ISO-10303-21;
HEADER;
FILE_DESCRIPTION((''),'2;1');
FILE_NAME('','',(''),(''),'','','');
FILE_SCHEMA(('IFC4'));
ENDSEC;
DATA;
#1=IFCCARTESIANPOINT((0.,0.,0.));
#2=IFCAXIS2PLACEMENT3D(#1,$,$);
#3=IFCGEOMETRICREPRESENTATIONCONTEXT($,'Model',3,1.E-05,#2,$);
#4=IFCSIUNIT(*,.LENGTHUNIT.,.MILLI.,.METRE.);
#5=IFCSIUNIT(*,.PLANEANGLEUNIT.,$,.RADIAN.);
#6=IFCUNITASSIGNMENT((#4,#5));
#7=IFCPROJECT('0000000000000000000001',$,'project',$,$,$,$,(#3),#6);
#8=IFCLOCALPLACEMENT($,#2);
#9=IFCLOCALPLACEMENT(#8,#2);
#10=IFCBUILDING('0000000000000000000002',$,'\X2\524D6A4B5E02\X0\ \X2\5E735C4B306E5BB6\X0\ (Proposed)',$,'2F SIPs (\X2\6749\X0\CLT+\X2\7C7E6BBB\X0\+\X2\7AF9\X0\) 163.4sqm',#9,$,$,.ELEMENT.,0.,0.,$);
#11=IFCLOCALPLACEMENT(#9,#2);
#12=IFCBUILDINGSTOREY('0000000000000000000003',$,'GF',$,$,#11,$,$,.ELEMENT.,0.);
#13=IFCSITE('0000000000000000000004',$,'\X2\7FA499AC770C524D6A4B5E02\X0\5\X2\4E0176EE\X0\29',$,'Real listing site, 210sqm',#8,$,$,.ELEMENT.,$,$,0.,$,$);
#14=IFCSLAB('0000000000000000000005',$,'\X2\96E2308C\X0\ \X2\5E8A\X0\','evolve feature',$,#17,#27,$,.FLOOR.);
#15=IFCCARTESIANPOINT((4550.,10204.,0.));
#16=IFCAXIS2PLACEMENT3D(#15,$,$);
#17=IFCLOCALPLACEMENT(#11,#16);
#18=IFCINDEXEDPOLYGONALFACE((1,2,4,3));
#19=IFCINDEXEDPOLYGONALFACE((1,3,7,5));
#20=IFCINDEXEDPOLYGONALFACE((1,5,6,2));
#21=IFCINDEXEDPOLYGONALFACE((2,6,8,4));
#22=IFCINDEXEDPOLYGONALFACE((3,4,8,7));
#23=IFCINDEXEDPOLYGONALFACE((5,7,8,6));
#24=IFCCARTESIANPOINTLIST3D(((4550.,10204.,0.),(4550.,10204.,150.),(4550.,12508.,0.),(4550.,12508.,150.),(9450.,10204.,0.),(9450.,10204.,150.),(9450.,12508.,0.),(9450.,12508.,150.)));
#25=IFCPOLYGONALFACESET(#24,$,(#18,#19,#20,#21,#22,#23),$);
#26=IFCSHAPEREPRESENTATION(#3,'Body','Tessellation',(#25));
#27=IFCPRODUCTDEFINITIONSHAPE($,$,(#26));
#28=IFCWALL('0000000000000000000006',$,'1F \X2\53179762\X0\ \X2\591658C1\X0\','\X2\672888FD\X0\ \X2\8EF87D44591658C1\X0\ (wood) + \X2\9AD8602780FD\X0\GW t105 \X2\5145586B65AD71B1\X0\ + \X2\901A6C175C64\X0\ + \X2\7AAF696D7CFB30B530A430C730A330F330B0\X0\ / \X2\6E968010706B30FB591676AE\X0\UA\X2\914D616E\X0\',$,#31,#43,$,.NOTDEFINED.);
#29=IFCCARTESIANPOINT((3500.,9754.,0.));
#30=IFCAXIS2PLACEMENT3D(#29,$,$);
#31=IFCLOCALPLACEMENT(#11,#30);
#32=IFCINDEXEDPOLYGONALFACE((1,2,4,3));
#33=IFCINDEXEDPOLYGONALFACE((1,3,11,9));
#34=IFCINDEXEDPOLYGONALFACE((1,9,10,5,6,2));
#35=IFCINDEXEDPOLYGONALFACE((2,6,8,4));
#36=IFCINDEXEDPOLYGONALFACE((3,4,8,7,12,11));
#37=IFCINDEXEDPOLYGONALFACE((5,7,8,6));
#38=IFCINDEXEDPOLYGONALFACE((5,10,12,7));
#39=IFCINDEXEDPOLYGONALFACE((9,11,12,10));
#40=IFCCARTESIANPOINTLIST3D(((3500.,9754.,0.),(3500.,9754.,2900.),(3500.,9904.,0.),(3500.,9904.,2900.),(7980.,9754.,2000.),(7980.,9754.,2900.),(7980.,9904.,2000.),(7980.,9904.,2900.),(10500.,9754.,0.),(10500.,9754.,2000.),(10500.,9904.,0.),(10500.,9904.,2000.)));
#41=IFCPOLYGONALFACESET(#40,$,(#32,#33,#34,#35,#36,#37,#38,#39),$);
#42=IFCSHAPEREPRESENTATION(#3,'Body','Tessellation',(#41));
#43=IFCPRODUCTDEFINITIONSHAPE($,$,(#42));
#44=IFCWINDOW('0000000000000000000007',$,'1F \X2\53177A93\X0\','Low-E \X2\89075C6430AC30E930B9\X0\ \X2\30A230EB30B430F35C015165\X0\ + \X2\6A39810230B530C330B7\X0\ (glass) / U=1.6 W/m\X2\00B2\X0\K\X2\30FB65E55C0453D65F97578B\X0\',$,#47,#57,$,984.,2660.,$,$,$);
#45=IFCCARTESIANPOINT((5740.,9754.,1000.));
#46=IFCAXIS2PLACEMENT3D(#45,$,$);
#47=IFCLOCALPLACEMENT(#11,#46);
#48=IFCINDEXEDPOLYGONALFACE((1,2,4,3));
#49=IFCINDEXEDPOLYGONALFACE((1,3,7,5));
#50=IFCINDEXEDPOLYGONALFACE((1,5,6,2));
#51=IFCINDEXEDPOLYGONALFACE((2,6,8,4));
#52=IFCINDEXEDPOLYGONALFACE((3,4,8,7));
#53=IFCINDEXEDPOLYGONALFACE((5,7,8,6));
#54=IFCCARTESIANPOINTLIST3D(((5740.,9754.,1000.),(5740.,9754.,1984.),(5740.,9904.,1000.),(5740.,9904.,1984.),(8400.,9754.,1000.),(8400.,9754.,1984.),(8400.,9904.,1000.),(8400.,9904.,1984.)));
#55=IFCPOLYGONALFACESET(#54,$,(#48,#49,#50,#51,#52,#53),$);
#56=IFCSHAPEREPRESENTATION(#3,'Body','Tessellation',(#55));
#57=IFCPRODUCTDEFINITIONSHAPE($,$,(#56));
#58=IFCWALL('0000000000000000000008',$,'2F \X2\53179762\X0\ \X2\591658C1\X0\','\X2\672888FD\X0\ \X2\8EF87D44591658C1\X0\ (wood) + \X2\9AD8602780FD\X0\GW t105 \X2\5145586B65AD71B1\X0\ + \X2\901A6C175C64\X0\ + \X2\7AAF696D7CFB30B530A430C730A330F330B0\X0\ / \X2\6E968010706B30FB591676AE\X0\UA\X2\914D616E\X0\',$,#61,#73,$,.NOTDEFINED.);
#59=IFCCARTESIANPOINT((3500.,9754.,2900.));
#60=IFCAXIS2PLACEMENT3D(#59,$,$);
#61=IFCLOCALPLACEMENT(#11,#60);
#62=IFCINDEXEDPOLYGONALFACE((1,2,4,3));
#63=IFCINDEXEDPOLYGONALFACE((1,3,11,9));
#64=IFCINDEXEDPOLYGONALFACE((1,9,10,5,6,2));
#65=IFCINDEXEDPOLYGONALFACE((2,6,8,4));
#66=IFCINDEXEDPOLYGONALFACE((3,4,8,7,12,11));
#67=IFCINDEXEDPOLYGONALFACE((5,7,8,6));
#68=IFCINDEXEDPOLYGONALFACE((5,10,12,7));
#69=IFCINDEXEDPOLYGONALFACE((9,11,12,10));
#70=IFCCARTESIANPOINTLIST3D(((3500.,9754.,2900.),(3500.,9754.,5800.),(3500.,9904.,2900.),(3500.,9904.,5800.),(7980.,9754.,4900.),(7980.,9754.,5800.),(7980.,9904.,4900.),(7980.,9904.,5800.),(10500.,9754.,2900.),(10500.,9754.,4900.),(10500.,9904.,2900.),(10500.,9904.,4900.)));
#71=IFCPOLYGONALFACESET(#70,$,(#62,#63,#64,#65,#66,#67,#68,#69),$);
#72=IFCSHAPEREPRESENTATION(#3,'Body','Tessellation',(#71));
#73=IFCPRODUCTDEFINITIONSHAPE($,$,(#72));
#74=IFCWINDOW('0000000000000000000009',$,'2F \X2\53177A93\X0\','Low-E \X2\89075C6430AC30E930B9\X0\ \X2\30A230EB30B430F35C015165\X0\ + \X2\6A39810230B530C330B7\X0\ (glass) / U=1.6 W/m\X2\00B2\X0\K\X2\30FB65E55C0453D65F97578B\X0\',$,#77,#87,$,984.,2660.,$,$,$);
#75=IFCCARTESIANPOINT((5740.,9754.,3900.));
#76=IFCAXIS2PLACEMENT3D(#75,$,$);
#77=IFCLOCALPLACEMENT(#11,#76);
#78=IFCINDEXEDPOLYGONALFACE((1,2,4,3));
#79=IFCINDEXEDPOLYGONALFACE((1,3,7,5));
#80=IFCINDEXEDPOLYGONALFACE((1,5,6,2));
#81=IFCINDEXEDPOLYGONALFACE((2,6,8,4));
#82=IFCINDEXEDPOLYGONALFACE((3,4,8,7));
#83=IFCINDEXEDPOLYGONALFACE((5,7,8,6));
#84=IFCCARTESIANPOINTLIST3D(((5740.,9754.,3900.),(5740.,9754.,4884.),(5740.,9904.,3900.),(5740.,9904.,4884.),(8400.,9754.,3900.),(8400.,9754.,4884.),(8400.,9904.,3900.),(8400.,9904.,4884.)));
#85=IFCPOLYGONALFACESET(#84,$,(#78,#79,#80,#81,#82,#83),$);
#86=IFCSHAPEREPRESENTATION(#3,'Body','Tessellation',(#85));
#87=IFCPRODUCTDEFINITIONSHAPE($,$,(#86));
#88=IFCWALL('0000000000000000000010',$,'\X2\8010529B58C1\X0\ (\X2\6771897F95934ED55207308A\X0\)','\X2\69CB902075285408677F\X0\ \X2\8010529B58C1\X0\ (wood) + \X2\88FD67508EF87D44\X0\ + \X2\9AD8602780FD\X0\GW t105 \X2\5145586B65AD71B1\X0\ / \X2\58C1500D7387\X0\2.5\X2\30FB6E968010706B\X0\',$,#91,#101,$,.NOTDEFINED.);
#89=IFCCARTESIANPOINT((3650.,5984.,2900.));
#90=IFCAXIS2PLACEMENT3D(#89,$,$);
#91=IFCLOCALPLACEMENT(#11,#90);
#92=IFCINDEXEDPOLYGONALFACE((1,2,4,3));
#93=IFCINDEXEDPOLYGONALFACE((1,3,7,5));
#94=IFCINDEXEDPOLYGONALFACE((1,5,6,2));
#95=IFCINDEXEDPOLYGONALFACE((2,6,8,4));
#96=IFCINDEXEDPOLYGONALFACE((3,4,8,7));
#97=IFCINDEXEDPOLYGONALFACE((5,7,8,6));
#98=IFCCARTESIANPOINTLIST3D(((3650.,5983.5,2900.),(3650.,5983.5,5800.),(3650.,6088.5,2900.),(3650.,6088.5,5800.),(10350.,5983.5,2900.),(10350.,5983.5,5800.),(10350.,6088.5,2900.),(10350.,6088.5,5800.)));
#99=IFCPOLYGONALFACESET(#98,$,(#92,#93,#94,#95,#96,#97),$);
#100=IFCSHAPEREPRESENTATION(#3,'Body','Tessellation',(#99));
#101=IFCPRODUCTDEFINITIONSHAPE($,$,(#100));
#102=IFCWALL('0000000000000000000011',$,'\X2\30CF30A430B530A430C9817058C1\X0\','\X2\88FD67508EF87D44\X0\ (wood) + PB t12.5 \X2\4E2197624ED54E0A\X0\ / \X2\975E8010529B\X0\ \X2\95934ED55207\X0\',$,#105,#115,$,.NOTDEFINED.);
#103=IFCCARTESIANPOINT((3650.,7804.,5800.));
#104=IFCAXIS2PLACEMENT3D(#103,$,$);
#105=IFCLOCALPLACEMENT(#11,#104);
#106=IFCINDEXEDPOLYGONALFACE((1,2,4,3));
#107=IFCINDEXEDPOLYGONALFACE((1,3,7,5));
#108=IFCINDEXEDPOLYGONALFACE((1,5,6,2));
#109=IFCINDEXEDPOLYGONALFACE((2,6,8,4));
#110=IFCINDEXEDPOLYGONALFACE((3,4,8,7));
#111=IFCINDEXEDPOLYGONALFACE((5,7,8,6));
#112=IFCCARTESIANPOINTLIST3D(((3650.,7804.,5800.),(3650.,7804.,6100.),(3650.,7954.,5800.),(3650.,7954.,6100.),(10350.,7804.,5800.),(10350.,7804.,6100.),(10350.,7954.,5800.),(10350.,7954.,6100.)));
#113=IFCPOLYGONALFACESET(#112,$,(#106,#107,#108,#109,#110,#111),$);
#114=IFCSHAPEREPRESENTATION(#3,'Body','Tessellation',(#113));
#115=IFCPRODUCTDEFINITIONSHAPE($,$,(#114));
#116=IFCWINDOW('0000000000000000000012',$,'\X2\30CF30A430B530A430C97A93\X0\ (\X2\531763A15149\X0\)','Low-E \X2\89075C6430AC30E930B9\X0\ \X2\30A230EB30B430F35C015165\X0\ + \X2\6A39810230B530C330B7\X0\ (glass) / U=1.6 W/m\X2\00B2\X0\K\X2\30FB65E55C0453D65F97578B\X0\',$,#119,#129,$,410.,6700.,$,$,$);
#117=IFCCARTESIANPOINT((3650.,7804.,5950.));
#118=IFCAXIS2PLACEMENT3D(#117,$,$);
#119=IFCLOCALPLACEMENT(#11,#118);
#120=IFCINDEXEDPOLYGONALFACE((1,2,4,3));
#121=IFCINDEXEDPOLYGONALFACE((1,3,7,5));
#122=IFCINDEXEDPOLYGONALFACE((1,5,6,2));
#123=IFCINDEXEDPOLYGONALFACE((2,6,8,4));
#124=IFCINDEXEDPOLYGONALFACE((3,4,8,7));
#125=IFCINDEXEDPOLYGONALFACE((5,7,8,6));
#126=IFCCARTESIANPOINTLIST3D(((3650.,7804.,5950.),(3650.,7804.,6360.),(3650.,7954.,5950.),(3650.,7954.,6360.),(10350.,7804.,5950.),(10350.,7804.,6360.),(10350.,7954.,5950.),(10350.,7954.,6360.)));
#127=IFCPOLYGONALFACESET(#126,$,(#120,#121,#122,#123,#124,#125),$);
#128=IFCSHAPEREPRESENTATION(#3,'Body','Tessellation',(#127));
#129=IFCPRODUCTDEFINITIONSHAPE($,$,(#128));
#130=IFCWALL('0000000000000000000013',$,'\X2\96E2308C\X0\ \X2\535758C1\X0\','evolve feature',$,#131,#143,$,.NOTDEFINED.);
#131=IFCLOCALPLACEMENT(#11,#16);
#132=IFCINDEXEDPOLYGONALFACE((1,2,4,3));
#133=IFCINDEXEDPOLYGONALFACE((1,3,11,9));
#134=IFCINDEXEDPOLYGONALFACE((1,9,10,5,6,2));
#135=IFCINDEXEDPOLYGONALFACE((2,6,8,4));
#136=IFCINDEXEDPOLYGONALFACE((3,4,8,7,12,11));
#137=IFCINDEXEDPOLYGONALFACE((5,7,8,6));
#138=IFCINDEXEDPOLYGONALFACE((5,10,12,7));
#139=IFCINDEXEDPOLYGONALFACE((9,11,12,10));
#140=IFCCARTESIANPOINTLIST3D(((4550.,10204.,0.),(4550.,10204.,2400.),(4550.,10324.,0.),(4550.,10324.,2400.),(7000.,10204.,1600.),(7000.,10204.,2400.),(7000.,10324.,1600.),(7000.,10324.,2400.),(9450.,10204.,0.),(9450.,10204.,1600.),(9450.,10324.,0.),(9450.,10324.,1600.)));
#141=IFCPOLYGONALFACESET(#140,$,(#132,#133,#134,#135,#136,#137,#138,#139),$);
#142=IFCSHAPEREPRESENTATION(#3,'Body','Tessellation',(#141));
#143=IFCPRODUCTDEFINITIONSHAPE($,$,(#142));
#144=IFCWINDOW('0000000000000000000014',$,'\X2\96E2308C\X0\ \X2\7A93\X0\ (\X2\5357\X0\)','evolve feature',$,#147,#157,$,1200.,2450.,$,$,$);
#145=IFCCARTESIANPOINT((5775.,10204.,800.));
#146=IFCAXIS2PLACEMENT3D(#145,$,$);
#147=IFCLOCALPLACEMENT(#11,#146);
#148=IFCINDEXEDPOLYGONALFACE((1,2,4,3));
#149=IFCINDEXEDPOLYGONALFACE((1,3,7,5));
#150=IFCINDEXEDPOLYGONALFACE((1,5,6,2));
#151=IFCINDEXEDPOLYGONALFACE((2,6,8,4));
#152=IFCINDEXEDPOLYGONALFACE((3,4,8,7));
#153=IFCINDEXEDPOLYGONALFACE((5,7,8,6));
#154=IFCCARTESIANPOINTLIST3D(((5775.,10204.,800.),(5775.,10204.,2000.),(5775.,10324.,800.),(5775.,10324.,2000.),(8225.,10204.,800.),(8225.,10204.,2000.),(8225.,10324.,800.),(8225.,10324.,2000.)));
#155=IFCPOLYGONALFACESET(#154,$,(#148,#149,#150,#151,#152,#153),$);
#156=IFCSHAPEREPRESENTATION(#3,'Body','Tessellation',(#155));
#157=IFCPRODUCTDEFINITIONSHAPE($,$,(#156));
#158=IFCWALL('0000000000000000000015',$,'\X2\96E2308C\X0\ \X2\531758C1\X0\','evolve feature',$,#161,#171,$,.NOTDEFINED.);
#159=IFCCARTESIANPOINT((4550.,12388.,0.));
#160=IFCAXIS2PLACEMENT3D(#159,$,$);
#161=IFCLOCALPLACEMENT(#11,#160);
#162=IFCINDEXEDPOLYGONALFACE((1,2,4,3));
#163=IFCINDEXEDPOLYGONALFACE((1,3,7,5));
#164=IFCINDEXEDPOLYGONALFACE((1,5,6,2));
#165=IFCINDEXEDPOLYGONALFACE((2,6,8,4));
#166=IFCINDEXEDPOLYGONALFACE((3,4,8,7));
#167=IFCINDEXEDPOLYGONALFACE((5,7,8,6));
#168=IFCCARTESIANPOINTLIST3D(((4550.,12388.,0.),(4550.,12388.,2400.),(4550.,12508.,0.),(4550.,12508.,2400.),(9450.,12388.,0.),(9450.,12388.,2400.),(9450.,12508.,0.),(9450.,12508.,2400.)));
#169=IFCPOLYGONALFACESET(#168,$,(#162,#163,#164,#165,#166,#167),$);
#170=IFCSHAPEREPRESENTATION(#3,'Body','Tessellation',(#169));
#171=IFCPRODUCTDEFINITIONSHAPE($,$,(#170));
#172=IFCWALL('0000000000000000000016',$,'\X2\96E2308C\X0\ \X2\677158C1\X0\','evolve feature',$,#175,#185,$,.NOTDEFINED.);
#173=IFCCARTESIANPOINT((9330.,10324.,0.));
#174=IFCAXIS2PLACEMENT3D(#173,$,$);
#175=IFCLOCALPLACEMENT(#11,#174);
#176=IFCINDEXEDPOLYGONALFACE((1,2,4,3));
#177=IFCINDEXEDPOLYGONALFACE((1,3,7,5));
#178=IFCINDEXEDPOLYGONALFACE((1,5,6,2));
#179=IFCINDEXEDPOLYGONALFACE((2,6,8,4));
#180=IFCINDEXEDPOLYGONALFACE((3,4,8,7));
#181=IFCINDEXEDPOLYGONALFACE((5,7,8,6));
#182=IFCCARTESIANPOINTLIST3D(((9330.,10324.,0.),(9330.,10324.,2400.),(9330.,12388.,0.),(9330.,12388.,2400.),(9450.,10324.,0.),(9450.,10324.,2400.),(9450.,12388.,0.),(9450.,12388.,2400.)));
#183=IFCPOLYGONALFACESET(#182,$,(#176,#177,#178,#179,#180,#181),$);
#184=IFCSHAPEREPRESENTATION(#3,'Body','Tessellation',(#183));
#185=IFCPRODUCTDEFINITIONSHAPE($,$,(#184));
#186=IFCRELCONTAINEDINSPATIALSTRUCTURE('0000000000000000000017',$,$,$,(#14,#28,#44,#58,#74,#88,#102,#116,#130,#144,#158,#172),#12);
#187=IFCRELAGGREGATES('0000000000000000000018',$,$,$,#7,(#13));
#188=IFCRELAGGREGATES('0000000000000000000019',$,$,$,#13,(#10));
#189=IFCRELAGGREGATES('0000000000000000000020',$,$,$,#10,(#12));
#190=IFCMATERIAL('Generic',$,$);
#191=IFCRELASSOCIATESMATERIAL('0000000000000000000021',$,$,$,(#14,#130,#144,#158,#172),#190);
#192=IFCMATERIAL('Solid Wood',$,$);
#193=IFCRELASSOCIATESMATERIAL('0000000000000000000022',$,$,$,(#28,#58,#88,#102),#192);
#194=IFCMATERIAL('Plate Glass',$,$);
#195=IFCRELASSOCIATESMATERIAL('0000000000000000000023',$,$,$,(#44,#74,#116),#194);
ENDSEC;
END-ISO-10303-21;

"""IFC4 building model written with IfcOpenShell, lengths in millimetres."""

from ifc_helpers import new_model, si_unit, frame, frame_2d, origin, place, context, project, spatial, rectangle, extrude, material, element, fill, save


model = new_model("IFC4")

# Units and contexts
model_context = context("Model", 3, precision=1e-05, world=origin())
ifc_project = project(units=[si_unit("LENGTHUNIT", "METRE", prefix="MILLI"), si_unit("PLANEANGLEUNIT", "RADIAN")], contexts=[model_context])

# Site, building, storey
site_placement = place(None, origin())
site = spatial("IfcSite", under=ifc_project, at=site_placement, Name="群馬県前橋市5丁目29", ObjectType="Real listing site, 210sqm", CompositionType="ELEMENT", RefElevation=0.0)
building_placement = place(site_placement, origin())
building = spatial("IfcBuilding", under=site, at=building_placement, Name="前橋市 平屋の家 (Proposed)", ObjectType="2F SIPs (杉CLT+籾殻+竹) 163.4sqm", CompositionType="ELEMENT", ElevationOfRefHeight=0.0, ElevationOfTerrain=0.0)
storey_placement = place(building_placement, origin())
storey = spatial("IfcBuildingStorey", under=building, at=storey_placement, Name="GF", CompositionType="ELEMENT", Elevation=0.0)

# Slab
ifc_material_1 = material(Name="Generic")
slab_placement = place(storey_placement, frame((4550.0, 10204.0, 0.0)))
element("IfcSlab", 1, at=slab_placement, inside=storey, material=ifc_material_1, Name="離れ 床", Description="evolve feature", PredefinedType="FLOOR", context=model_context, shape_type="SweptSolid", body=[
    extrude(rectangle(XDim=4900.0, YDim=2304.0, at=frame_2d((2450.0, 1152.0))), frame((4550.0, 10204.0, 0.0)), (0.0, 0.0, 1.0), 150.0),
])

# Wall, opening, window
ifc_material_2 = material(Name="Solid Wood")
wall_1_placement = place(storey_placement, frame((3500.0, 9754.0, 0.0)))
wall_1 = element("IfcWall", 2, at=wall_1_placement, inside=storey, material=ifc_material_2, Name="1F 北面 外壁", Description="木製 軸組外壁 (wood) + 高性能GW t105 充填断熱 + 通気層 + 窯業系サイディング / 準耐火・外皮UA配慮", PredefinedType="NOTDEFINED", context=model_context, shape_type="SweptSolid", body=[
    extrude(rectangle(XDim=7000.0, YDim=150.0, at=frame_2d((3500.0, 75.0))), frame((3500.0, 9754.0, 0.0)), (0.0, 0.0, 1.0), 2900.0),
])
opening_1_placement = place(storey_placement, frame((5740.0, 9754.0, 1000.0)))
opening_1 = element("IfcOpeningElement", 3, at=opening_1_placement, cuts=wall_1, PredefinedType="NOTDEFINED", context=model_context, shape_type="SweptSolid", body=[
    extrude(rectangle(XDim=2660.0, YDim=150.0, at=frame_2d((1330.0, 75.0))), frame((5740.0, 9754.0, 1000.0)), (0.0, 0.0, 1.0), 984.0),
])
ifc_material_3 = material(Name="Plate Glass")
window_1_placement = place(storey_placement, frame((5740.0, 9754.0, 1000.0)))
window_1 = element("IfcWindow", 4, at=window_1_placement, inside=storey, material=ifc_material_3, Name="1F 北窓", Description="Low-E 複層ガラス アルゴン封入 + 樹脂サッシ (glass) / U=1.6 W/m²K・日射取得型", OverallHeight=984.0, OverallWidth=2660.0, context=model_context, shape_type="SweptSolid", body=[
    extrude(rectangle(XDim=2660.0, YDim=150.0, at=frame_2d((1330.0, 75.0))), frame((5740.0, 9754.0, 1000.0)), (0.0, 0.0, 1.0), 984.0),
])
fill(opening_1, window_1)

# Wall, opening, window
wall_2_placement = place(storey_placement, frame((3500.0, 9754.0, 2900.0)))
wall_2 = element("IfcWall", 5, at=wall_2_placement, inside=storey, material=ifc_material_2, Name="2F 北面 外壁", Description="木製 軸組外壁 (wood) + 高性能GW t105 充填断熱 + 通気層 + 窯業系サイディング / 準耐火・外皮UA配慮", PredefinedType="NOTDEFINED", context=model_context, shape_type="SweptSolid", body=[
    extrude(rectangle(XDim=7000.0, YDim=150.0, at=frame_2d((3500.0, 75.0))), frame((3500.0, 9754.0, 2900.0)), (0.0, 0.0, 1.0), 2900.0),
])
opening_2_placement = place(storey_placement, frame((5740.0, 9754.0, 3900.0)))
opening_2 = element("IfcOpeningElement", 6, at=opening_2_placement, cuts=wall_2, PredefinedType="NOTDEFINED", context=model_context, shape_type="SweptSolid", body=[
    extrude(rectangle(XDim=2660.0, YDim=150.0, at=frame_2d((1330.0, 75.0))), frame((5740.0, 9754.0, 3900.0)), (0.0, 0.0, 1.0), 984.0),
])
window_2_placement = place(storey_placement, frame((5740.0, 9754.0, 3900.0)))
window_2 = element("IfcWindow", 7, at=window_2_placement, inside=storey, material=ifc_material_3, Name="2F 北窓", Description="Low-E 複層ガラス アルゴン封入 + 樹脂サッシ (glass) / U=1.6 W/m²K・日射取得型", OverallHeight=984.0, OverallWidth=2660.0, context=model_context, shape_type="SweptSolid", body=[
    extrude(rectangle(XDim=2660.0, YDim=150.0, at=frame_2d((1330.0, 75.0))), frame((5740.0, 9754.0, 3900.0)), (0.0, 0.0, 1.0), 984.0),
])
fill(opening_2, window_2)

# Wall
wall_3_placement = place(storey_placement, frame((3650.0, 5984.0, 2900.0)))
element("IfcWall", 8, at=wall_3_placement, inside=storey, material=ifc_material_2, Name="耐力壁 (東西間仕切り)", Description="構造用合板 耐力壁 (wood) + 製材軸組 + 高性能GW t105 充填断熱 / 壁倍率2.5・準耐火", PredefinedType="NOTDEFINED", context=model_context, shape_type="SweptSolid", body=[
    extrude(rectangle(XDim=6700.0, YDim=105.0, at=frame_2d((3350.0, 52.0))), frame((3650.0, 5984.0, 2900.0)), (0.0, 0.0, 1.0), 2900.0),
])

# Walls, openings, windows
wall_4_placement = place(storey_placement, frame((3650.0, 7804.0, 5800.0)))
wall_4 = element("IfcWall", 9, at=wall_4_placement, inside=storey, material=ifc_material_2, Name="ハイサイド腰壁", Description="製材軸組 (wood) + PB t12.5 両面仕上 / 非耐力 間仕切", PredefinedType="NOTDEFINED", context=model_context, shape_type="SweptSolid", body=[
    extrude(rectangle(XDim=6700.0, YDim=150.0, at=frame_2d((3350.0, 75.0))), frame((3650.0, 7804.0, 5800.0)), (0.0, 0.0, 1.0), 700.0),
])
opening_3_placement = place(storey_placement, frame((3650.0, 7804.0, 5950.0)))
opening_3 = element("IfcOpeningElement", 10, at=opening_3_placement, cuts=wall_4, PredefinedType="NOTDEFINED", context=model_context, shape_type="SweptSolid", body=[
    extrude(rectangle(XDim=6700.0, YDim=150.0, at=frame_2d((3350.0, 75.0))), frame((3650.0, 7804.0, 5950.0)), (0.0, 0.0, 1.0), 410.0),
])
window_3_placement = place(storey_placement, frame((3650.0, 7804.0, 5950.0)))
window_3 = element("IfcWindow", 11, at=window_3_placement, inside=storey, material=ifc_material_3, Name="ハイサイド窓 (北採光)", Description="Low-E 複層ガラス アルゴン封入 + 樹脂サッシ (glass) / U=1.6 W/m²K・日射取得型", OverallHeight=410.0, OverallWidth=6700.0, context=model_context, shape_type="SweptSolid", body=[
    extrude(rectangle(XDim=6700.0, YDim=150.0, at=frame_2d((3350.0, 75.0))), frame((3650.0, 7804.0, 5950.0)), (0.0, 0.0, 1.0), 410.0),
])
fill(opening_3, window_3)
wall_5_placement = place(storey_placement, frame((4550.0, 10204.0, 0.0)))
wall_5 = element("IfcWall", 12, at=wall_5_placement, inside=storey, material=ifc_material_1, Name="離れ 南壁", Description="evolve feature", PredefinedType="NOTDEFINED", context=model_context, shape_type="SweptSolid", body=[
    extrude(rectangle(XDim=4900.0, YDim=120.0, at=frame_2d((2450.0, 60.0))), frame((4550.0, 10204.0, 0.0)), (0.0, 0.0, 1.0), 2400.0),
])
opening_4_placement = place(storey_placement, frame((5775.0, 10204.0, 800.0)))
opening_4 = element("IfcOpeningElement", 13, at=opening_4_placement, cuts=wall_5, PredefinedType="NOTDEFINED", context=model_context, shape_type="SweptSolid", body=[
    extrude(rectangle(XDim=2450.0, YDim=120.0, at=frame_2d((1225.0, 60.0))), frame((5775.0, 10204.0, 800.0)), (0.0, 0.0, 1.0), 1200.0),
])
window_4_placement = place(storey_placement, frame((5775.0, 10204.0, 800.0)))
window_4 = element("IfcWindow", 14, at=window_4_placement, inside=storey, material=ifc_material_1, Name="離れ 窓 (南)", Description="evolve feature", OverallHeight=1200.0, OverallWidth=2450.0, context=model_context, shape_type="SweptSolid", body=[
    extrude(rectangle(XDim=2450.0, YDim=120.0, at=frame_2d((1225.0, 60.0))), frame((5775.0, 10204.0, 800.0)), (0.0, 0.0, 1.0), 1200.0),
])
fill(opening_4, window_4)

# Walls
wall_6_placement = place(storey_placement, frame((4550.0, 12388.0, 0.0)))
element("IfcWall", 15, at=wall_6_placement, inside=storey, material=ifc_material_1, Name="離れ 北壁", Description="evolve feature", PredefinedType="NOTDEFINED", context=model_context, shape_type="SweptSolid", body=[
    extrude(rectangle(XDim=4900.0, YDim=120.0, at=frame_2d((2450.0, 60.0))), frame((4550.0, 12388.0, 0.0)), (0.0, 0.0, 1.0), 2400.0),
])
wall_7_placement = place(storey_placement, frame((9330.0, 10324.0, 0.0)))
element("IfcWall", 16, at=wall_7_placement, inside=storey, material=ifc_material_1, Name="離れ 東壁", Description="evolve feature", PredefinedType="NOTDEFINED", context=model_context, shape_type="SweptSolid", body=[
    extrude(rectangle(XDim=120.0, YDim=2064.0, at=frame_2d((60.0, 1032.0))), frame((9330.0, 10324.0, 0.0)), (0.0, 0.0, 1.0), 2400.0),
])

save(model, "model.ifc")
